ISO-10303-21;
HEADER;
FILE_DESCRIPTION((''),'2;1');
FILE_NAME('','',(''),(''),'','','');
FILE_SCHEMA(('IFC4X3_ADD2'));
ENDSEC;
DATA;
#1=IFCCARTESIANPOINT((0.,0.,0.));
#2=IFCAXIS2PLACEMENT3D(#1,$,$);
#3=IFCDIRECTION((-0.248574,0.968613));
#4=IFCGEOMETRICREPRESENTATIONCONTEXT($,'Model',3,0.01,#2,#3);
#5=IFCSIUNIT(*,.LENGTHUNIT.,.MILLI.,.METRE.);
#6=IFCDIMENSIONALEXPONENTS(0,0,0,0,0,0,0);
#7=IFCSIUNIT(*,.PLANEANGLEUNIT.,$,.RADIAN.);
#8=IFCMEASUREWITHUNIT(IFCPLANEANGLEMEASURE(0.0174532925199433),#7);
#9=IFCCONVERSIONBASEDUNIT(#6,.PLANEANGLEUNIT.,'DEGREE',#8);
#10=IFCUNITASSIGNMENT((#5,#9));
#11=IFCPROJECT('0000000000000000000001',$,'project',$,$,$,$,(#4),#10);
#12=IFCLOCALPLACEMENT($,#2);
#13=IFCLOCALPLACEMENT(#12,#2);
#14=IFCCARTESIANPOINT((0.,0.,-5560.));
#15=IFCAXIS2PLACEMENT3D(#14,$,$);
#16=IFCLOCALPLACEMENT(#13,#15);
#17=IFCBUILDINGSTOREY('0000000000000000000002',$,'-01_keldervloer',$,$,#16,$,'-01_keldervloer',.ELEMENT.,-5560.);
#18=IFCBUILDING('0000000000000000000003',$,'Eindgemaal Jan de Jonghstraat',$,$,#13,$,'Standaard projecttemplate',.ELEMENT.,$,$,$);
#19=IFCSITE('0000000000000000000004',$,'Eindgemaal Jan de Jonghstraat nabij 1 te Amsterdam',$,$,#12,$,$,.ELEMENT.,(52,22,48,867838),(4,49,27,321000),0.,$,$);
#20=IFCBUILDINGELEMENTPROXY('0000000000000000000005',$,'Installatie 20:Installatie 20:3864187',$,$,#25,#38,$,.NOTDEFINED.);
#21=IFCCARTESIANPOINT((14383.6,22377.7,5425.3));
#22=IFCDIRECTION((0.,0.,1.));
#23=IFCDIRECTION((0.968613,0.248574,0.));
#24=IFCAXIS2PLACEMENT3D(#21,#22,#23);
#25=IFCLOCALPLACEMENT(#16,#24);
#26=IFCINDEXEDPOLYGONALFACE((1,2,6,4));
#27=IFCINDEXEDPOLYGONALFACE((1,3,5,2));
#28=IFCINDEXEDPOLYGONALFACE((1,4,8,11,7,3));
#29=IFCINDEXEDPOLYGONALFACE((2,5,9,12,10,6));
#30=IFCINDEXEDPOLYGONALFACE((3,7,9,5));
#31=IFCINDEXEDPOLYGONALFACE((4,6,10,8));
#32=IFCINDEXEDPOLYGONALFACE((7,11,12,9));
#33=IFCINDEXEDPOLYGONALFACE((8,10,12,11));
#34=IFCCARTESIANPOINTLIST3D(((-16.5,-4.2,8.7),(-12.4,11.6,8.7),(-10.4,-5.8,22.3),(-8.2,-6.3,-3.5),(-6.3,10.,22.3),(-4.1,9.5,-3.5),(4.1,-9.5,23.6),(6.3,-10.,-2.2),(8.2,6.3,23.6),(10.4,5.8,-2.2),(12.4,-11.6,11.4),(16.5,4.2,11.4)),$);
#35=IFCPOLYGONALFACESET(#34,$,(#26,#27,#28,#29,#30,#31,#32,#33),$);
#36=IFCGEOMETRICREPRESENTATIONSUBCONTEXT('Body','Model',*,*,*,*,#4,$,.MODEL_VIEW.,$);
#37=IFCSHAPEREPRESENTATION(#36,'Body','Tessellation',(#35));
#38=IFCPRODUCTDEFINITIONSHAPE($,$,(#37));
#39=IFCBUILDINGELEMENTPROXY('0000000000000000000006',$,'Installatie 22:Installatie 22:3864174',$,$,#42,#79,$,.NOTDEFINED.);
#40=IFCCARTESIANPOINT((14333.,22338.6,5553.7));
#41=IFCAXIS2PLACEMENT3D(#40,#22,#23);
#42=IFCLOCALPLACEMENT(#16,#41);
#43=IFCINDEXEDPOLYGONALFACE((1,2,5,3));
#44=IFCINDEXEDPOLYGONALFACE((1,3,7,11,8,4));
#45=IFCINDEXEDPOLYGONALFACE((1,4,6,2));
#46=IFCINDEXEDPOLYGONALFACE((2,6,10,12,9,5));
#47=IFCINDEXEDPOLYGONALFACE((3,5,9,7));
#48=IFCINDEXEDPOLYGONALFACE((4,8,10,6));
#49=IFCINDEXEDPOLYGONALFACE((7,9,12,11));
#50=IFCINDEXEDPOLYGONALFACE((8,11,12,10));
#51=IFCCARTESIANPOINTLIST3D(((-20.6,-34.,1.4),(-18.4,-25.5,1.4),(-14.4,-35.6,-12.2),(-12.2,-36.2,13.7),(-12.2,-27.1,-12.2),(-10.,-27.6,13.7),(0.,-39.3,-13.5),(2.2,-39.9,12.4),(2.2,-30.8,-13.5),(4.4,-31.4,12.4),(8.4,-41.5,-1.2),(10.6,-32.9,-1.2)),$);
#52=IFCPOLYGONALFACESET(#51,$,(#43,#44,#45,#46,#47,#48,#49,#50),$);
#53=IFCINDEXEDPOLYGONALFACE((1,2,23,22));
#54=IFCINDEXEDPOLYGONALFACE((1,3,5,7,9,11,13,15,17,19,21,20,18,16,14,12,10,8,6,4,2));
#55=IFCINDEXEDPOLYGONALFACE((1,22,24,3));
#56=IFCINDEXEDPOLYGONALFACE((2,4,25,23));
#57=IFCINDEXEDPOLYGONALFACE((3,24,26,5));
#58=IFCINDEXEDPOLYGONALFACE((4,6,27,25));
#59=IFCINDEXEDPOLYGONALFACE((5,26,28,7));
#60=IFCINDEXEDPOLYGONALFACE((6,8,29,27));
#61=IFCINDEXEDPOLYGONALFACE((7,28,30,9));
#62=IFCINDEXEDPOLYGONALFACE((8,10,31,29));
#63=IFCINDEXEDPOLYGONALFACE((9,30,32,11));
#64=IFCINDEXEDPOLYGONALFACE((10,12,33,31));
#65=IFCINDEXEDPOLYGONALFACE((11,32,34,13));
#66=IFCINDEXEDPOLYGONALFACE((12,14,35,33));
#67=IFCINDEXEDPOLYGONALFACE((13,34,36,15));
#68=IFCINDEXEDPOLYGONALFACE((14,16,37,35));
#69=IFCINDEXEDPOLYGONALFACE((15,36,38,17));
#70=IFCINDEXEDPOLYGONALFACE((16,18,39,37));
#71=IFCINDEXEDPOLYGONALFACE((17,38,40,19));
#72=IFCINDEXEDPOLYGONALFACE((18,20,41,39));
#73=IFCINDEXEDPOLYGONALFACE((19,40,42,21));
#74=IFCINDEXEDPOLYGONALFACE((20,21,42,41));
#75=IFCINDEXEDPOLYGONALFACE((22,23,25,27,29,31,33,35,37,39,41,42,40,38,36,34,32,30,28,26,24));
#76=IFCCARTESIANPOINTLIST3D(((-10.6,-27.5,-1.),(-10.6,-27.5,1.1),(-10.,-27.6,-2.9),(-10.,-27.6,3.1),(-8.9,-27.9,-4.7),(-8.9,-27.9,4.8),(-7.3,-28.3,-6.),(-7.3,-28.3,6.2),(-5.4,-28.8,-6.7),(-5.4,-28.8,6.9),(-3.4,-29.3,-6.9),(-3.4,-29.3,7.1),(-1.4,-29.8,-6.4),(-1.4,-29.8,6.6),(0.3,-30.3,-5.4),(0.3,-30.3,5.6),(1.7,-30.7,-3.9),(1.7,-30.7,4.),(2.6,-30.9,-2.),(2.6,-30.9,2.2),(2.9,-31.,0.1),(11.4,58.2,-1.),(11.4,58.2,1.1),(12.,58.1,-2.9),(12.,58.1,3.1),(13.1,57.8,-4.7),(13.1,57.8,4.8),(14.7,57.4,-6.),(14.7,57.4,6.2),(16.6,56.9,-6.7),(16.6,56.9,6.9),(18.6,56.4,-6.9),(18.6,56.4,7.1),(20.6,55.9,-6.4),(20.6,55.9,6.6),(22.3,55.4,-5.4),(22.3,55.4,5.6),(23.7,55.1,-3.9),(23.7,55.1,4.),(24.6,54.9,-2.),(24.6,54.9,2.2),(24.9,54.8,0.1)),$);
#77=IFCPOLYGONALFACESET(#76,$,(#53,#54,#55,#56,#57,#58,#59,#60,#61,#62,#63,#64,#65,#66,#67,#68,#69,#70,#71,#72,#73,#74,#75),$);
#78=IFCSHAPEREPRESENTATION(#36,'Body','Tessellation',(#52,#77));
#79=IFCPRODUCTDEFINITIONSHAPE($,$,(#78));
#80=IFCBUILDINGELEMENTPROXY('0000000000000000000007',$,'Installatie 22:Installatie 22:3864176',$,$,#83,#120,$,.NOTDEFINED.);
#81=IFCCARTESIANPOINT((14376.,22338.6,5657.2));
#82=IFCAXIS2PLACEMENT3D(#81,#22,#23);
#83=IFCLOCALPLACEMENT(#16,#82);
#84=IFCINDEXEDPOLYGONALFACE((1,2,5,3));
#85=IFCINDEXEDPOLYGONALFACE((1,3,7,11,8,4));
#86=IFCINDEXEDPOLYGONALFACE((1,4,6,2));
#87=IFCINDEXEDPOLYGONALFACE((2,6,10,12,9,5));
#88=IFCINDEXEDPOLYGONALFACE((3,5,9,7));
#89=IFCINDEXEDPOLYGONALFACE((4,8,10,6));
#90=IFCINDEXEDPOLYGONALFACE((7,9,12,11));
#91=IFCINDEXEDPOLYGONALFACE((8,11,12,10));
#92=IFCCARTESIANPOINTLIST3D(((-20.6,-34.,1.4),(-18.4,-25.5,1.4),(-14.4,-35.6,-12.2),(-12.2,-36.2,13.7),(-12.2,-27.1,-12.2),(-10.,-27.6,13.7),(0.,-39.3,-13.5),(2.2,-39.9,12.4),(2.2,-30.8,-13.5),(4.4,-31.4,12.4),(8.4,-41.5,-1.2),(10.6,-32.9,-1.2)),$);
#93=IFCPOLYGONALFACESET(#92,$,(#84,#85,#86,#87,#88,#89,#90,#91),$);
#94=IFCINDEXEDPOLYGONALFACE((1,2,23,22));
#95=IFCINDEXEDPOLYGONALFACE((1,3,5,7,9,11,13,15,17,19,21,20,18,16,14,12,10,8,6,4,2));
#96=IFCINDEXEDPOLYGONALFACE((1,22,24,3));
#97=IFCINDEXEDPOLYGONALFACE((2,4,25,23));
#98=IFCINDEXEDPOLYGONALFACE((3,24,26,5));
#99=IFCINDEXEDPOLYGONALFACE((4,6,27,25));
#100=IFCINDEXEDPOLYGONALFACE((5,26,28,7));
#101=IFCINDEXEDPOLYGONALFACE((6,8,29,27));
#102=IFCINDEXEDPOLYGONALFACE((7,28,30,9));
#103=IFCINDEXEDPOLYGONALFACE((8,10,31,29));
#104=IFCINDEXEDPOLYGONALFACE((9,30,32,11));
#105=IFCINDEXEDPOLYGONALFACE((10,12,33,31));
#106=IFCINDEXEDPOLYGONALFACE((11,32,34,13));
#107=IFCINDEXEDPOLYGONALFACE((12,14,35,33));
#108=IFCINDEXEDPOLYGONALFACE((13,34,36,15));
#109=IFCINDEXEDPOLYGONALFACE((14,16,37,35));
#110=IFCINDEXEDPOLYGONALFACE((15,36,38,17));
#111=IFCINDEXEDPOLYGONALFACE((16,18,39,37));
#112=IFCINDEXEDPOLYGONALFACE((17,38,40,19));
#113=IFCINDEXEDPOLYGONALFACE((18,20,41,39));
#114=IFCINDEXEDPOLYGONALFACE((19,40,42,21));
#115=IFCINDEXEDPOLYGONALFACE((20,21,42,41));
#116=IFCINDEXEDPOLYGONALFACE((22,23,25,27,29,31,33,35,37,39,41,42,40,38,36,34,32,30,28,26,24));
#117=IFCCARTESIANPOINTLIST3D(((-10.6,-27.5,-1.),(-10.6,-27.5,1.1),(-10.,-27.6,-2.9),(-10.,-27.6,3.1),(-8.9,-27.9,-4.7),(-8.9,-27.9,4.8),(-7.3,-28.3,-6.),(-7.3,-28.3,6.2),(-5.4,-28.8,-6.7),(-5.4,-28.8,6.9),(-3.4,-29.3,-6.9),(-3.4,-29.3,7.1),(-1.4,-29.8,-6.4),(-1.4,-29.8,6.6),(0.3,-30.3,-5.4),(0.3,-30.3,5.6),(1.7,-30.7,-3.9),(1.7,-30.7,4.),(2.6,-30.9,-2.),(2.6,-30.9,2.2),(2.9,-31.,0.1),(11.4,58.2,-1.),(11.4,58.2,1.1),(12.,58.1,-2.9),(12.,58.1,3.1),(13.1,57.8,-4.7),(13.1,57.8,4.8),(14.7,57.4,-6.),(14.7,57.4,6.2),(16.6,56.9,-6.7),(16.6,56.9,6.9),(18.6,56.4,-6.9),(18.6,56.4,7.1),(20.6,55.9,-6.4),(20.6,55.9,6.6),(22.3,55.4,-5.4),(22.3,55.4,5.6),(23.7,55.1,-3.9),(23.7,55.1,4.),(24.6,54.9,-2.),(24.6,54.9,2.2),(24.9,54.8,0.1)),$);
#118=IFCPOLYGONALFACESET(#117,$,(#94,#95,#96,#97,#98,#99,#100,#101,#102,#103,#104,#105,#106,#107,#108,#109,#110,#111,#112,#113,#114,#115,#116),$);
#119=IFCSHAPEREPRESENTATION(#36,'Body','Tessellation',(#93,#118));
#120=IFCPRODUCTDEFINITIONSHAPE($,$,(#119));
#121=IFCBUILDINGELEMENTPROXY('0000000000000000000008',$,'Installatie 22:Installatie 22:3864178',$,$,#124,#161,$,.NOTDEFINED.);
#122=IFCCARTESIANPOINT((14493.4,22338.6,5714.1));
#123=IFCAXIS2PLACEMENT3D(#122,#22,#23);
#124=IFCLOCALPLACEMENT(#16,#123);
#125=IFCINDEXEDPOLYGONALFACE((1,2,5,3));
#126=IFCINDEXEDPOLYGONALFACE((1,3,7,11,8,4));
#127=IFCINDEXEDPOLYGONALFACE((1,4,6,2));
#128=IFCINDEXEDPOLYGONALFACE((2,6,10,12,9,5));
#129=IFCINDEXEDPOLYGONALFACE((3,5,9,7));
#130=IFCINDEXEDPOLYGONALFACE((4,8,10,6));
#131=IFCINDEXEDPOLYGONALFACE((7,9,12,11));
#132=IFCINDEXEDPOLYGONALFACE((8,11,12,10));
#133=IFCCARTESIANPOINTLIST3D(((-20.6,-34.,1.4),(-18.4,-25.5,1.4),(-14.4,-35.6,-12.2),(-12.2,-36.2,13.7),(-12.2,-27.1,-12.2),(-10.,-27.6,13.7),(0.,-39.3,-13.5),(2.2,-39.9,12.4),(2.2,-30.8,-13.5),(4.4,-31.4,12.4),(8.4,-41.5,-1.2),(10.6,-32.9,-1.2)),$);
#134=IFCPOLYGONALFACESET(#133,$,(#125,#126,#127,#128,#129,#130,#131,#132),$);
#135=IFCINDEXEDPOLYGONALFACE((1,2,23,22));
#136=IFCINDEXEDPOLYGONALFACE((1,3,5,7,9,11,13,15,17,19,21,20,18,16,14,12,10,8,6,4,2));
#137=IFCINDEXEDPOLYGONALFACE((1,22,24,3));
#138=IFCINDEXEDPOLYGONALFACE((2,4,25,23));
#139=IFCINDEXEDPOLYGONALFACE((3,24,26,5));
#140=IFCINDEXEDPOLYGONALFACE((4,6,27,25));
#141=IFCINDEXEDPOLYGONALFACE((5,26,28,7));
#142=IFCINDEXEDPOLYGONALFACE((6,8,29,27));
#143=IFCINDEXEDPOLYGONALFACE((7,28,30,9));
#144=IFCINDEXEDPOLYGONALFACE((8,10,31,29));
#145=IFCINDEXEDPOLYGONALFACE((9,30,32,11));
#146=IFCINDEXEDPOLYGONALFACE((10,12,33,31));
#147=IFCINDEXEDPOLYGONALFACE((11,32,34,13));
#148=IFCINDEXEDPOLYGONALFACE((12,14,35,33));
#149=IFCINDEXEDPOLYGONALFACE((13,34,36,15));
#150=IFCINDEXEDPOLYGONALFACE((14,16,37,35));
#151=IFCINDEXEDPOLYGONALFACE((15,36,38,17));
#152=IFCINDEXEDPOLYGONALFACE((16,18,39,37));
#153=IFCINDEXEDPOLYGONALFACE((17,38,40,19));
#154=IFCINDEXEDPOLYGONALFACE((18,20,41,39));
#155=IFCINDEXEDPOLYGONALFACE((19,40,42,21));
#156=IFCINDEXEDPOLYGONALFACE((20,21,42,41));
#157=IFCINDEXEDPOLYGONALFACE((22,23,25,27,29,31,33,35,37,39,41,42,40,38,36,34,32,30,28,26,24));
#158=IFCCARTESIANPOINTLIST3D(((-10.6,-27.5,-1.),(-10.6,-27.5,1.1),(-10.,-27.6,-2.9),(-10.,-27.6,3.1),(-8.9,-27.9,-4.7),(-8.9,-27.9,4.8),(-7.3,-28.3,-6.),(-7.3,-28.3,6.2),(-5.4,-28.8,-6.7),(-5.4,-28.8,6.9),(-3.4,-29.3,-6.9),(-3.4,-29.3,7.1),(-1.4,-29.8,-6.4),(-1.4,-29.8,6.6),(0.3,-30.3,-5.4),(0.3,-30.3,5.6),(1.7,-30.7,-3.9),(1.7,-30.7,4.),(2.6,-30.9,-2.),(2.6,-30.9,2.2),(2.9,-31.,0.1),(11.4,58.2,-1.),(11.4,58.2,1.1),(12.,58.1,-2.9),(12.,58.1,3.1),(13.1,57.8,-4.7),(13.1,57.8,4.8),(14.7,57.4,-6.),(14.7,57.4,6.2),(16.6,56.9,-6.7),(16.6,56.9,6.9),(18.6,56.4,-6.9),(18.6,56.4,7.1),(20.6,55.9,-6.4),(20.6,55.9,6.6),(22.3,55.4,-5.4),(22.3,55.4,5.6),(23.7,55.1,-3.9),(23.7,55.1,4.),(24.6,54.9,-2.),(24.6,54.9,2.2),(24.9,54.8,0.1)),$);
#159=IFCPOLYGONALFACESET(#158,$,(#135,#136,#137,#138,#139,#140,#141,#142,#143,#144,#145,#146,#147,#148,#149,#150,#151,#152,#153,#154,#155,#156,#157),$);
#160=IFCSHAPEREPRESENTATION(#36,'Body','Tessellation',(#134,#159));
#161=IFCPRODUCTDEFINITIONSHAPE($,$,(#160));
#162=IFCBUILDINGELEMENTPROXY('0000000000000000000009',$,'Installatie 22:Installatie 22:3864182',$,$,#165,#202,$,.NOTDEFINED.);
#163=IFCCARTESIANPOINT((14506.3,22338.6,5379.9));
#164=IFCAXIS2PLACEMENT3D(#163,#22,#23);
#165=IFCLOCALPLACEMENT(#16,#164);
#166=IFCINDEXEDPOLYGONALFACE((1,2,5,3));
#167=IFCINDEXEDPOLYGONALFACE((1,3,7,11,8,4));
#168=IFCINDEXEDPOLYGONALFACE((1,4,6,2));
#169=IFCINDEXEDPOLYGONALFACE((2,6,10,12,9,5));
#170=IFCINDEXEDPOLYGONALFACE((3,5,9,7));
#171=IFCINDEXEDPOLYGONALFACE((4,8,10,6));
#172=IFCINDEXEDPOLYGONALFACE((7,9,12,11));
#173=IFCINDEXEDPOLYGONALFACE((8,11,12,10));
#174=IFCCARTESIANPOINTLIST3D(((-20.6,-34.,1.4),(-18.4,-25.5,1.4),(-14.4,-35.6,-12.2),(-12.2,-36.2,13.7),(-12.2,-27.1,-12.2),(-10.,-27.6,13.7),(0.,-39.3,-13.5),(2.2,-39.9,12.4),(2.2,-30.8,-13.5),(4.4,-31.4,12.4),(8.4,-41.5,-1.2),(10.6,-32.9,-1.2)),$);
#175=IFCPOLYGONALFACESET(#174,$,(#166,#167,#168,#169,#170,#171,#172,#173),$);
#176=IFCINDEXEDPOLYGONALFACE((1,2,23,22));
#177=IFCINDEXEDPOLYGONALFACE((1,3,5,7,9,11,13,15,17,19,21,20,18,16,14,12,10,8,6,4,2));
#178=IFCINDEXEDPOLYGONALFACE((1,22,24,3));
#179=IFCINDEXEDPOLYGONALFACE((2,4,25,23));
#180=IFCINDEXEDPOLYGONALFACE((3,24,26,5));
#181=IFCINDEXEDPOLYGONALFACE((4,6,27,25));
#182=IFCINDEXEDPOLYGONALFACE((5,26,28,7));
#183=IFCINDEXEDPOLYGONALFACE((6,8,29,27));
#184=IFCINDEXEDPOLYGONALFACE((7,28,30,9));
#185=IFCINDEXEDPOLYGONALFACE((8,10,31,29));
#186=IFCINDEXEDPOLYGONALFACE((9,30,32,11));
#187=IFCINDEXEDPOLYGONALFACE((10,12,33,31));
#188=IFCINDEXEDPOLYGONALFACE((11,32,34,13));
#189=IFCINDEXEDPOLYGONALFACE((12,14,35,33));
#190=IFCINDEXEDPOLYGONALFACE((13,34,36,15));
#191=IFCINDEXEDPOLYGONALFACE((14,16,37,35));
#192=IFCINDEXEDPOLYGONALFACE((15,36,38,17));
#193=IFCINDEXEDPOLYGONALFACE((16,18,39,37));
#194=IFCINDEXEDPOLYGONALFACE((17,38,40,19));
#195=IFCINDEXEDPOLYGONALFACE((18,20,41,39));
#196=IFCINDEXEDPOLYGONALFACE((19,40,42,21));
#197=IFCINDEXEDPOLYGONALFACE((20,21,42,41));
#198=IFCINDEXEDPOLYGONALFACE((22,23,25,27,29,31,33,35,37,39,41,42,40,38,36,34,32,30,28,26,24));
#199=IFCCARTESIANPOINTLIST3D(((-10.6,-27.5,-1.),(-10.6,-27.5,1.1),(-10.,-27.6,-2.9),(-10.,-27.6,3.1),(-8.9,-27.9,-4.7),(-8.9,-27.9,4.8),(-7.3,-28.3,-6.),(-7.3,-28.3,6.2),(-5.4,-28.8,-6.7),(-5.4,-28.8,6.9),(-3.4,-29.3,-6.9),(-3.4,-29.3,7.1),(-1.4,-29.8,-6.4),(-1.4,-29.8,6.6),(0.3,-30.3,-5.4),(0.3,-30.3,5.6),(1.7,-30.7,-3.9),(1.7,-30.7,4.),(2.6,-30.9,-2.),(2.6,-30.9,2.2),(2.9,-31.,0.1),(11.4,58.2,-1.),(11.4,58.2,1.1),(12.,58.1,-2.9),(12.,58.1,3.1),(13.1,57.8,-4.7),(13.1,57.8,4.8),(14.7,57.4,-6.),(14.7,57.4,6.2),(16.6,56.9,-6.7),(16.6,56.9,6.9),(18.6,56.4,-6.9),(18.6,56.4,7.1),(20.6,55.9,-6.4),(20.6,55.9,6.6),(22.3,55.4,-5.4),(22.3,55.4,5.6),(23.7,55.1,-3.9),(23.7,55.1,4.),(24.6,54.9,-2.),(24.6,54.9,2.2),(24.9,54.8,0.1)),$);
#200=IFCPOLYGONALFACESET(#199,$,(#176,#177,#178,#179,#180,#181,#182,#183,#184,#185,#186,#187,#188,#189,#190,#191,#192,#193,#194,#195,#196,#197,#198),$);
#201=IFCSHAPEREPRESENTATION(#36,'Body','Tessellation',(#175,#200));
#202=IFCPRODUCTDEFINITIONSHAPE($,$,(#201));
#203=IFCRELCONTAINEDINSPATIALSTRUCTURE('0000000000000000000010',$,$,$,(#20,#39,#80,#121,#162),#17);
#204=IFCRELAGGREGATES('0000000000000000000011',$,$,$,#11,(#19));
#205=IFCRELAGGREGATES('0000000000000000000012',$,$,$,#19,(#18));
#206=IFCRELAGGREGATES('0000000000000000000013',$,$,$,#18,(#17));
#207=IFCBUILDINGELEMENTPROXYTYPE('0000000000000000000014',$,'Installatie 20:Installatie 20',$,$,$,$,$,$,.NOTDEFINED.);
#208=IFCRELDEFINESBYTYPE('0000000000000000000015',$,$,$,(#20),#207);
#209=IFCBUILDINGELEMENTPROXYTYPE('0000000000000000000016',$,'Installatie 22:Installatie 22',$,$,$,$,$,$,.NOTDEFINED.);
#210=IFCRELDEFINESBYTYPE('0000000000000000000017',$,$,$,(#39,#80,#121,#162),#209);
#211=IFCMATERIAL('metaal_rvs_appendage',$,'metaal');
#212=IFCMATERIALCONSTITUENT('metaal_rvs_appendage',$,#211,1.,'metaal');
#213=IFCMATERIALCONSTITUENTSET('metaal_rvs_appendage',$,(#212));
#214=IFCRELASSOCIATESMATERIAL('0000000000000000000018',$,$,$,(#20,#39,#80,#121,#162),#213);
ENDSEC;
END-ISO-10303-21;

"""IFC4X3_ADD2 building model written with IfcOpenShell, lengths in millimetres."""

from ifc_helpers import new_model, entity, si_unit, converted_unit, direction, frame, frame_2d, origin, place, context, subcontext, project, spatial, polyline, circle, outline, extrude, source, transform, mapped, material, constituent, constituent_set, type_object, type_shapes, element, save


model = new_model("IFC4X3_ADD2")

# Units and contexts
model_context = context("Model", 3, precision=0.01, world=origin(), true_north=direction((-0.248574, 0.968613)))
body_context = subcontext(model_context, "Body", "Model", "MODEL_VIEW")
ifc_project = project(units=[si_unit("LENGTHUNIT", "METRE", prefix="MILLI"), converted_unit("PLANEANGLEUNIT", "DEGREE", entity("IfcPlaneAngleMeasure", 0.0174532925199433), si_unit("PLANEANGLEUNIT", "RADIAN"), dimensions=[0, 0, 0, 0, 0, 0, 0])], contexts=[model_context])

# Site, building, storey
site_placement = place(None, origin())
site = spatial("IfcSite", under=ifc_project, at=site_placement, Name="Eindgemaal Jan de Jonghstraat nabij 1 te Amsterdam", CompositionType="ELEMENT", RefLatitude=(52, 22, 48, 867838), RefLongitude=(4, 49, 27, 321000), RefElevation=0.0)
building_placement = place(site_placement, origin())
building = spatial("IfcBuilding", under=site, at=building_placement, Name="Eindgemaal Jan de Jonghstraat", LongName="Standaard projecttemplate", CompositionType="ELEMENT")
storey_placement = place(building_placement, frame((0.0, 0.0, -5560.0)))
storey = spatial("IfcBuildingStorey", under=building, at=storey_placement, Name="-01_keldervloer", LongName="-01_keldervloer", CompositionType="ELEMENT", Elevation=-5560.0)

# Building element proxies
ifc_material_1 = material(Name="metaal_rvs_appendage", Category="metaal")
ifc_constituent_1 = constituent(ifc_material_1, Name="metaal_rvs_appendage", Category="metaal", fraction=1.0)
ifc_constituent_set_1 = constituent_set(constituents=[ifc_constituent_1], Name="metaal_rvs_appendage")
building_element_proxy_type_1 = type_object("IfcBuildingElementProxyType", Name="Installatie 20:Installatie 20", PredefinedType="NOTDEFINED")
shared_shape_1 = source(origin(), body_context, "Body", "SweptSolid", [
    extrude(outline(polyline([(-7.5, -13.0), (7.5, -13.0), (15.0, 0.0), (7.5, 13.0), (-7.5, 13.0), (-15.0, 0.0), (-7.5, -13.0)])), frame((-2.0, -7.9, 10.0), z_axis=(0.248574, 0.968613, 0.0), x_axis=(0.964927, -0.247628, 0.087156)), (0.0, 0.0, 1.0), 16.3),
])
type_shapes(building_element_proxy_type_1, [shared_shape_1])
for number, where, z_axis, x_axis, name in (
    (1, (14383.6, 22377.7, 5425.3), (0.0, 0.0, 1.0), (0.968613, 0.248574, 0.0), "Installatie 20:Installatie 20:3864187"),
):
    element("IfcBuildingElementProxy", number, at=place(storey_placement, frame(where, z_axis=z_axis, x_axis=x_axis)), inside=storey, type_object=building_element_proxy_type_1, material=ifc_constituent_set_1, Name=name, PredefinedType="NOTDEFINED", context=body_context, shape_type="MappedRepresentation", body=[
        mapped(shared_shape_1, transform((0.0, 0.0, 0.0), scale=1.0)),
    ])
building_element_proxy_type_2 = type_object("IfcBuildingElementProxyType", Name="Installatie 22:Installatie 22", PredefinedType="NOTDEFINED")
shared_shape_2 = source(origin(), body_context, "Body", "SweptSolid", [
    extrude(outline(polyline([(-7.5, -13.0), (7.5, -13.0), (15.0, 0.0), (7.5, 13.0), (-7.5, 13.0), (-15.0, 0.0), (-7.5, -13.0)])), frame((-6.1, -37.8, 0.1), z_axis=(0.248574, 0.968613, 0.0), x_axis=(-0.555573, 0.142576, -0.819152)), (0.0, 0.0, 1.0), 8.8),
    extrude(circle(Radius=7.0, at=frame_2d((0.0, 0.0), x_axis=(1.0, 0.0))), frame((-3.9, -29.2, 0.1), z_axis=(0.248574, 0.968613, 0.0), x_axis=(0.968613, -0.248574, 0.0)), (0.0, 0.0, 1.0), 88.5),
])
type_shapes(building_element_proxy_type_2, [shared_shape_2])
for number, where, z_axis, x_axis, name in (
    (2, (14333.0, 22338.6, 5553.7), (0.0, 0.0, 1.0), (0.968613, 0.248574, 0.0), "Installatie 22:Installatie 22:3864174"),
    (3, (14376.0, 22338.6, 5657.2), (0.0, 0.0, 1.0), (0.968613, 0.248574, 0.0), "Installatie 22:Installatie 22:3864176"),
    (4, (14493.4, 22338.6, 5714.1), (0.0, 0.0, 1.0), (0.968613, 0.248574, 0.0), "Installatie 22:Installatie 22:3864178"),
    (5, (14506.3, 22338.6, 5379.9), (0.0, 0.0, 1.0), (0.968613, 0.248574, 0.0), "Installatie 22:Installatie 22:3864182"),
):
    element("IfcBuildingElementProxy", number, at=place(storey_placement, frame(where, z_axis=z_axis, x_axis=x_axis)), inside=storey, type_object=building_element_proxy_type_2, material=ifc_constituent_set_1, Name=name, PredefinedType="NOTDEFINED", context=body_context, shape_type="MappedRepresentation", body=[
        mapped(shared_shape_2, transform((0.0, 0.0, 0.0), scale=1.0)),
    ])

save(model, "model.ifc")
